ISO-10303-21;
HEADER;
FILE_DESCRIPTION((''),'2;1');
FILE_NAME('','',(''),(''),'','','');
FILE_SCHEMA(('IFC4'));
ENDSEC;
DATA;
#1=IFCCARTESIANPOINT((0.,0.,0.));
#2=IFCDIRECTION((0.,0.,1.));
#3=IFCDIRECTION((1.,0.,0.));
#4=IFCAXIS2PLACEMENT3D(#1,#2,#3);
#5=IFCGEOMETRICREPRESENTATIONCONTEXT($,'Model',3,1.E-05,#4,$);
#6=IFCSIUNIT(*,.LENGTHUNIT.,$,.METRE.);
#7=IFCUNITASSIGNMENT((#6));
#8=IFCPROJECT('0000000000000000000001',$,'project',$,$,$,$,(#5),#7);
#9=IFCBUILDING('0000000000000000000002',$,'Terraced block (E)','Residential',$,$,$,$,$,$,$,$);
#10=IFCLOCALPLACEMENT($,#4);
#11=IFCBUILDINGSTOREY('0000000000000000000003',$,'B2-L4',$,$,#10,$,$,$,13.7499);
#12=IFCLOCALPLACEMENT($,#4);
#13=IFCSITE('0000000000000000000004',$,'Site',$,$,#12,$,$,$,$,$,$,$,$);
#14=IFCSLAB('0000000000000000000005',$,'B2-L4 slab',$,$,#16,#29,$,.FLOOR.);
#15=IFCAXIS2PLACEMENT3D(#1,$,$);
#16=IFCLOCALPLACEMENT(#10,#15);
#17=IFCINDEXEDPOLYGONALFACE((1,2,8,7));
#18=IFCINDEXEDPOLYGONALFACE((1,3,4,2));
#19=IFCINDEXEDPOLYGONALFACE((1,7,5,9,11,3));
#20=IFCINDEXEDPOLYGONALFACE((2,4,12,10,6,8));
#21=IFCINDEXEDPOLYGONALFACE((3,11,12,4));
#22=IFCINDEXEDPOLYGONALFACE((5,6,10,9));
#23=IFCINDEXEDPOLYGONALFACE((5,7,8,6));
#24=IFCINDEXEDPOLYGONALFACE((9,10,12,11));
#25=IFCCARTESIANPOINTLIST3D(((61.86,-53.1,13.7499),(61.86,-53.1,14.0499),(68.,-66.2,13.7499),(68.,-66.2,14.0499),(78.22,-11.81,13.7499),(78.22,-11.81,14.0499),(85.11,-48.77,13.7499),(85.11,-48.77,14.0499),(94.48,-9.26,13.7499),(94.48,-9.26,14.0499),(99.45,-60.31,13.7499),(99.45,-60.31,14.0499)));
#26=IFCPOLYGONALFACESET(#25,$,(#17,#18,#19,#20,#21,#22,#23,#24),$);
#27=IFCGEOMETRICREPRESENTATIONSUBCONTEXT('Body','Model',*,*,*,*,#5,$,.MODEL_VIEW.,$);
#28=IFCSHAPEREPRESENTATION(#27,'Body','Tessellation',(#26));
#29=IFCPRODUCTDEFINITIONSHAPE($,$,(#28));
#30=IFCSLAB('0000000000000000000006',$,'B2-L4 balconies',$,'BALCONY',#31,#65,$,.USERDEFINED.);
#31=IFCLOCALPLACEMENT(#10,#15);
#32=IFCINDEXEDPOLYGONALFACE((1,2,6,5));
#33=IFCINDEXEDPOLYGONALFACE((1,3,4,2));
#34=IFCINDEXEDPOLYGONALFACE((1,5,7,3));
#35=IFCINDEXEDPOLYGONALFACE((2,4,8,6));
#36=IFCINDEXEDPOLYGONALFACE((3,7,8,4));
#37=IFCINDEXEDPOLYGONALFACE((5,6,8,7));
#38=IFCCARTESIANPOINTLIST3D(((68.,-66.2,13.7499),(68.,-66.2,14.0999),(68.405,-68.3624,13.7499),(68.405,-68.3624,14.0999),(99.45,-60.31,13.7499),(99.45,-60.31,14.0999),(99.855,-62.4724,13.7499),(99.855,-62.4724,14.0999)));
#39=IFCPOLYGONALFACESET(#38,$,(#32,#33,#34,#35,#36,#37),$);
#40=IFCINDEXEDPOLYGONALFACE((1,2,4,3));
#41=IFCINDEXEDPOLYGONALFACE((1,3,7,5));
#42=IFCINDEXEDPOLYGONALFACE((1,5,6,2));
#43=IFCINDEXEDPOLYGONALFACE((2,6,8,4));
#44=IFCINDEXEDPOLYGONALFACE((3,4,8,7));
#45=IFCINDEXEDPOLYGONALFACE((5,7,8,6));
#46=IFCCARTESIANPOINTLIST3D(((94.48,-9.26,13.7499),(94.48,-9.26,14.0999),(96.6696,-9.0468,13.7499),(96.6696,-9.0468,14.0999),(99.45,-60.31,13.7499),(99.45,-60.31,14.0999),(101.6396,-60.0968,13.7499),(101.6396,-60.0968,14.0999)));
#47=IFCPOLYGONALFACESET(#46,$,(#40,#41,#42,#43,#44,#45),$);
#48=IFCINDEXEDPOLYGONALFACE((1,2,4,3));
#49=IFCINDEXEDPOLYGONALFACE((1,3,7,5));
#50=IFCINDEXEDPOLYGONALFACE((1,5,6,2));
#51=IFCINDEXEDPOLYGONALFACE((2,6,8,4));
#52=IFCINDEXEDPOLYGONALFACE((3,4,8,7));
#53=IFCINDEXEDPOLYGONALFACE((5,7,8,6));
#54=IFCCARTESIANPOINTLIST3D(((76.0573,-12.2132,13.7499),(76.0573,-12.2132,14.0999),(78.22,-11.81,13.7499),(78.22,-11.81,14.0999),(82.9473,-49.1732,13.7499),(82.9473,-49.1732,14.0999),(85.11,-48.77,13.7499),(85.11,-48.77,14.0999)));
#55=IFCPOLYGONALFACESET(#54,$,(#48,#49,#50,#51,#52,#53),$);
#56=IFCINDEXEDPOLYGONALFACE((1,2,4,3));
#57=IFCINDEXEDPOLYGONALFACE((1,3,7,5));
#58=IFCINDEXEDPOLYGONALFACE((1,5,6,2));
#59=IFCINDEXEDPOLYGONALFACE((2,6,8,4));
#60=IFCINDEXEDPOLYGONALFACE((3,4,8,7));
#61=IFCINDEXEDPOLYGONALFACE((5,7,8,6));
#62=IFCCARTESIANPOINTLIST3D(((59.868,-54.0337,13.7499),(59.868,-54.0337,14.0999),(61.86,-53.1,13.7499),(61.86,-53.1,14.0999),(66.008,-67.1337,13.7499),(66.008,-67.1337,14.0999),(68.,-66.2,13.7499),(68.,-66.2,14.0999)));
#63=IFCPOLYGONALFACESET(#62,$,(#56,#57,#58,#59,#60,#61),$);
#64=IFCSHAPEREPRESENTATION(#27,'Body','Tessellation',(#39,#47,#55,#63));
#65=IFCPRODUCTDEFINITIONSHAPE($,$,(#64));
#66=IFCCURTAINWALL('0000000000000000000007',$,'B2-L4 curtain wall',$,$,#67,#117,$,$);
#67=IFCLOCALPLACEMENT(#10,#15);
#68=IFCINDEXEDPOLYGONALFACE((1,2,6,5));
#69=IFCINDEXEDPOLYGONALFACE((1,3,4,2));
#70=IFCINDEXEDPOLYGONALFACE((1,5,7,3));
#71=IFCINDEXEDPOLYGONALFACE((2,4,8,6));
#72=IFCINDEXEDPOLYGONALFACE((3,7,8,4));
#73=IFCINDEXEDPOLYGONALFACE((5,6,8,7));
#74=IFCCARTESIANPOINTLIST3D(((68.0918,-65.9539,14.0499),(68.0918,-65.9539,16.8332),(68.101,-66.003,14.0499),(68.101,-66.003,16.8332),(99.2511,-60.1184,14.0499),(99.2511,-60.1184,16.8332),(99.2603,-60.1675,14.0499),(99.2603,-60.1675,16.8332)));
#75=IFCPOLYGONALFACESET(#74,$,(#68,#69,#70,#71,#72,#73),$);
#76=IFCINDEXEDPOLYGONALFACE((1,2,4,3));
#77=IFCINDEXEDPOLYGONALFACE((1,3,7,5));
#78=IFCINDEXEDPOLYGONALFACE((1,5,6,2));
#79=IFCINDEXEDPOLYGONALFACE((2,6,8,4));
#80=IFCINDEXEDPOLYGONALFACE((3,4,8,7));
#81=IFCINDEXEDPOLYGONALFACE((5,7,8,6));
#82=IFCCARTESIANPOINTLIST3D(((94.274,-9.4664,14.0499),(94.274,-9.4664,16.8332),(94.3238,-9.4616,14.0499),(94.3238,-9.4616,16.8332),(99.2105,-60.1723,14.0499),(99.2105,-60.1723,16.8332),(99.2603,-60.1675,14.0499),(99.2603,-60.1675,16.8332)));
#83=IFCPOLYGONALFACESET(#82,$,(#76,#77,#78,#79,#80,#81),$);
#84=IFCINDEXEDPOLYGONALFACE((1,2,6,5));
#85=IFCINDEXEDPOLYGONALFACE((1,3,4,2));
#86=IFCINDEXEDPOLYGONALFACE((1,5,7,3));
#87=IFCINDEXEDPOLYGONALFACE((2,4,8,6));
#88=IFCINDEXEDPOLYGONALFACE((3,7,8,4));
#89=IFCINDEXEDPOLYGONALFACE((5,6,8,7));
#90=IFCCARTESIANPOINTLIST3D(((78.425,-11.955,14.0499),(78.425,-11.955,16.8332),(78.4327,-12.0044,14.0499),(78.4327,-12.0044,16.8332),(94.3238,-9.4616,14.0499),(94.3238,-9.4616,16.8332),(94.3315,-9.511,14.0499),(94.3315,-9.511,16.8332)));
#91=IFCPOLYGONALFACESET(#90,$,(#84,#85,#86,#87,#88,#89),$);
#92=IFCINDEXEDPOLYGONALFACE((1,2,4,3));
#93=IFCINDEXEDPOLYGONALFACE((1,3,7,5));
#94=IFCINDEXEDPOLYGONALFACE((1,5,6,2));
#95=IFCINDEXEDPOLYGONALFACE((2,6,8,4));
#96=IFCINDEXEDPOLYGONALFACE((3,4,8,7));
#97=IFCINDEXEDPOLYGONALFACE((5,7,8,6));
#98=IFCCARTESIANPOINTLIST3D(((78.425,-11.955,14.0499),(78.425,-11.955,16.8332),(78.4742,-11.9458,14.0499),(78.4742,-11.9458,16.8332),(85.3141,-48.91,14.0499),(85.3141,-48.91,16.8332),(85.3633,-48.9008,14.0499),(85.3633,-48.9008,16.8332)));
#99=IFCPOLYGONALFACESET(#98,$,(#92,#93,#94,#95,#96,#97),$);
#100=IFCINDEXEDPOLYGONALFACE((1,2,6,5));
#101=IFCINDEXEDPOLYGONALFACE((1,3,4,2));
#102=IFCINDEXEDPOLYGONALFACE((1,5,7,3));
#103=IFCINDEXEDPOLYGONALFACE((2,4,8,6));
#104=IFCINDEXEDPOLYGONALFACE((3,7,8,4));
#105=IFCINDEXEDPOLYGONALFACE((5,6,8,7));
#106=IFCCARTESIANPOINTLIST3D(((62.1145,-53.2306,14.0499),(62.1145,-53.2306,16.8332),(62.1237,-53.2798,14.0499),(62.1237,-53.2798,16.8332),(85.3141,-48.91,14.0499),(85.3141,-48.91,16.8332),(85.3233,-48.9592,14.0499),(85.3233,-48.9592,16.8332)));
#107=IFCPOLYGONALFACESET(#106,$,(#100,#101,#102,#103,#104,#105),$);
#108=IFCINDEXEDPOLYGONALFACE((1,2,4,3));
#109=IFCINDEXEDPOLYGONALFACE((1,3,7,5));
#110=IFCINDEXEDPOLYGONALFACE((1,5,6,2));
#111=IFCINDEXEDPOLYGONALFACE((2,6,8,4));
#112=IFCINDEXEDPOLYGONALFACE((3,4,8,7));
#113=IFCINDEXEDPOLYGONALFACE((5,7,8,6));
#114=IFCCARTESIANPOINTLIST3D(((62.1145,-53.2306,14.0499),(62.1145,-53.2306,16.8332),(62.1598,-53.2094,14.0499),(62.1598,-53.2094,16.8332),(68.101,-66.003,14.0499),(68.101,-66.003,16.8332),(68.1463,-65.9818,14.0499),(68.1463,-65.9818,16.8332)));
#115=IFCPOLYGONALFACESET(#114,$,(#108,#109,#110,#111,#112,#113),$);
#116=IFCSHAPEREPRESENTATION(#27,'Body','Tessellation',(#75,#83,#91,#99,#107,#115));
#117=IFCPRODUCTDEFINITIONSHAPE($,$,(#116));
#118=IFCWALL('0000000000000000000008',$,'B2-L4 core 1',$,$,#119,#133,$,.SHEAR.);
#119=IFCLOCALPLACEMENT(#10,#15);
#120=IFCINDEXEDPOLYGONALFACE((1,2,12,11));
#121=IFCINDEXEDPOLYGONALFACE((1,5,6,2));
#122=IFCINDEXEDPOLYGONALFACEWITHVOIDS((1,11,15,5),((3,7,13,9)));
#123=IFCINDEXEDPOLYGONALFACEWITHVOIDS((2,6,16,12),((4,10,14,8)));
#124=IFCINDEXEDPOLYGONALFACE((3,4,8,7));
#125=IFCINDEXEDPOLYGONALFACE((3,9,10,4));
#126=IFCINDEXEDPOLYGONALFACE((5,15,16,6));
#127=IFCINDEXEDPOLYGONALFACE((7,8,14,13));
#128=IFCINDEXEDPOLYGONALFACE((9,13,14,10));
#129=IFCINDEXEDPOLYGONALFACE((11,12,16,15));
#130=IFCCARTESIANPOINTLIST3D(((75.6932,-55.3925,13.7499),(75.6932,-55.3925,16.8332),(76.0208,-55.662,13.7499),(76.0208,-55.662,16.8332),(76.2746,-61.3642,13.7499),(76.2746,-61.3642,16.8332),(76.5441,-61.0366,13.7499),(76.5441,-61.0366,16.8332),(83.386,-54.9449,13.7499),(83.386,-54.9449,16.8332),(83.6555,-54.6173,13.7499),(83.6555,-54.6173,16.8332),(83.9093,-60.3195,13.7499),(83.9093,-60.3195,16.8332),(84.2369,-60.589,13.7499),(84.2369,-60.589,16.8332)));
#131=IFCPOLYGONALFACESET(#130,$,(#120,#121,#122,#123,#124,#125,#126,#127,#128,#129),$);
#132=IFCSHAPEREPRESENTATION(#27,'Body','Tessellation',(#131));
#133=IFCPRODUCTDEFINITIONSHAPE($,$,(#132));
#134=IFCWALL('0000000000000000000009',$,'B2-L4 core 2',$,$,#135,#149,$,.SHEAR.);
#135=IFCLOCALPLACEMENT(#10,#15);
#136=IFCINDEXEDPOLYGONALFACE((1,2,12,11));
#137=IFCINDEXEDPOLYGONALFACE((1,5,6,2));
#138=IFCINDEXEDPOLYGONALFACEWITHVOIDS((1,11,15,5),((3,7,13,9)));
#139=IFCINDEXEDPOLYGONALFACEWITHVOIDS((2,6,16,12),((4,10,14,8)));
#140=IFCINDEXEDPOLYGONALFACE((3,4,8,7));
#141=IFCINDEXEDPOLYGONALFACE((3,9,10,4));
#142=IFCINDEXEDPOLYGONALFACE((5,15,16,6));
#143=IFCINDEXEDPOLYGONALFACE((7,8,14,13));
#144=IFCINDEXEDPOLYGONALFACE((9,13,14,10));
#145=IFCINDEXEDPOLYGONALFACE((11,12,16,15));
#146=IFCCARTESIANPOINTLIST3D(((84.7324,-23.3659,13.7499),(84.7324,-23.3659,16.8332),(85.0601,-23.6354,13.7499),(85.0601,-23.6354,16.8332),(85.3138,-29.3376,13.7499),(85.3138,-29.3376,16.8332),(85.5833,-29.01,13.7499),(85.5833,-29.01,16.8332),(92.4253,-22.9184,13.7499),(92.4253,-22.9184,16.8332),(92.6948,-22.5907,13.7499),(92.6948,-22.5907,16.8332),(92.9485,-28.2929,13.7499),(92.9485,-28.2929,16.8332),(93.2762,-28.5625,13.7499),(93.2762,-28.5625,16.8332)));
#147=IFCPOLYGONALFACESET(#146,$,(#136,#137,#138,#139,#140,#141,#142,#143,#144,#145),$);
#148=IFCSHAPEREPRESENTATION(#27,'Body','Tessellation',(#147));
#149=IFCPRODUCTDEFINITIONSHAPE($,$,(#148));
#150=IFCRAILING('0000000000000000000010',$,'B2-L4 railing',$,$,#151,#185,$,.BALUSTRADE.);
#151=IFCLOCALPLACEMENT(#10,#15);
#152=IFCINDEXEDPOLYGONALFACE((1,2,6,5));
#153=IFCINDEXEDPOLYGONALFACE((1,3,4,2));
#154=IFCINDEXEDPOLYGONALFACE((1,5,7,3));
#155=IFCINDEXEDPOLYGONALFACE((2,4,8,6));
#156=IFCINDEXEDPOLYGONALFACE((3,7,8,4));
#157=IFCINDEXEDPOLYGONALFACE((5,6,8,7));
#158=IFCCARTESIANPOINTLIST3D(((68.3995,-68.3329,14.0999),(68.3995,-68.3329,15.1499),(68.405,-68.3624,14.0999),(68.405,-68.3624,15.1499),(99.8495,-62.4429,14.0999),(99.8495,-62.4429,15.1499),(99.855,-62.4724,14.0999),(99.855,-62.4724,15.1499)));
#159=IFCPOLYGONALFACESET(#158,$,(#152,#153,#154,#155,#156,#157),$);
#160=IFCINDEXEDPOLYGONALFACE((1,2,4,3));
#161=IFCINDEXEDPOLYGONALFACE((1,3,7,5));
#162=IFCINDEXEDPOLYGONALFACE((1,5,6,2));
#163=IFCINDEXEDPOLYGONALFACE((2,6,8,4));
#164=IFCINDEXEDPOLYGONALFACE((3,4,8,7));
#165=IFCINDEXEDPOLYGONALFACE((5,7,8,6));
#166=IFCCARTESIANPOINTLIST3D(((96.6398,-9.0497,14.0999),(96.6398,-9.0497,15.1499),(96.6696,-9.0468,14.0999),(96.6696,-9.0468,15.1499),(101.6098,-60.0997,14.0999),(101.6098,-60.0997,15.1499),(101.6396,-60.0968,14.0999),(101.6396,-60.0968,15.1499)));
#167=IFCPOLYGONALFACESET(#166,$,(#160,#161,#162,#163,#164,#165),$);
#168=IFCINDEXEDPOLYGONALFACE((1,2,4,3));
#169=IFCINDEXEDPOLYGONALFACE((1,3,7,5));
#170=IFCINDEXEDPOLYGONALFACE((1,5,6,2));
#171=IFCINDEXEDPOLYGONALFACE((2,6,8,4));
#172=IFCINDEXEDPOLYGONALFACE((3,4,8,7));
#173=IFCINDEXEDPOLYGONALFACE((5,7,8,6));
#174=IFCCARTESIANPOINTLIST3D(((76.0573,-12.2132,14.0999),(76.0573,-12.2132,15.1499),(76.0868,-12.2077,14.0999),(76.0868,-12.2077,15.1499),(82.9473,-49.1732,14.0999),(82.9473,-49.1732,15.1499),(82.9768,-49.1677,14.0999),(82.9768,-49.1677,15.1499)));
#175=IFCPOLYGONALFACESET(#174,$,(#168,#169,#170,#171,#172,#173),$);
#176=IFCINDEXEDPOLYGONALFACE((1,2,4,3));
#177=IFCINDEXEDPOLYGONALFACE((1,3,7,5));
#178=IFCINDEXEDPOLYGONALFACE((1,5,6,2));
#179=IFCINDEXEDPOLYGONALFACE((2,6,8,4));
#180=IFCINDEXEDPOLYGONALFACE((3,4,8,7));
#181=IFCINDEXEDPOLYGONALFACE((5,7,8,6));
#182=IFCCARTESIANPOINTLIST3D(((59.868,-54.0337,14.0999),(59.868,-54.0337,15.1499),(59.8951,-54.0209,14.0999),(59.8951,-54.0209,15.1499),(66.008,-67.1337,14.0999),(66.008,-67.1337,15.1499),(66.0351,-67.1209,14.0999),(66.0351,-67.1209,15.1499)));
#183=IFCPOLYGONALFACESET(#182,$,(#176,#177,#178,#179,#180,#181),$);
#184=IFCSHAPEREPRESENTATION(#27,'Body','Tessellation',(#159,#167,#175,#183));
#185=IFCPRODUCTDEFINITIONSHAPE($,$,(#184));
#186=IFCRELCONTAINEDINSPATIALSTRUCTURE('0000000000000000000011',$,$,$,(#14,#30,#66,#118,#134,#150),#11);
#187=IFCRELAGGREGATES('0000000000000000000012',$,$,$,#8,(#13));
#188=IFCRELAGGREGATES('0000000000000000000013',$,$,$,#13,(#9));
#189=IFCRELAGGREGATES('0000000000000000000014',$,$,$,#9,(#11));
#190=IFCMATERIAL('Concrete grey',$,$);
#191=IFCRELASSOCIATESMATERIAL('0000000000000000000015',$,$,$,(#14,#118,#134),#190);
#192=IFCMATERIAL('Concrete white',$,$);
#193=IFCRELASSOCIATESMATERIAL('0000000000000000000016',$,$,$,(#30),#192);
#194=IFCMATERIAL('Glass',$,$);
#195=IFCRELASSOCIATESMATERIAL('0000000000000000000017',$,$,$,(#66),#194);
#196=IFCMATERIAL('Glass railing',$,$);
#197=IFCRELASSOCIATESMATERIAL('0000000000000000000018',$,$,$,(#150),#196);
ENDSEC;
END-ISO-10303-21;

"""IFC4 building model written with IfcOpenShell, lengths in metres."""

from ifc_helpers import new_model, si_unit, frame, origin_with_axes, place, context, subcontext, project, spatial, polyline, outline, extrude, material, element, save


model = new_model("IFC4")

# Units and contexts
model_context = context("Model", 3, precision=1e-05, world=origin_with_axes())
body_context = subcontext(model_context, "Body", "Model", "MODEL_VIEW")
ifc_project = project(units=[si_unit("LENGTHUNIT", "METRE")], contexts=[model_context])

# Site, building, storey
site_placement = place(None, origin_with_axes())
site = spatial("IfcSite", under=ifc_project, at=site_placement, Name="Site")
building = spatial("IfcBuilding", under=site, Name="Terraced block (E)", Description="Residential")
storey_placement = place(None, origin_with_axes())
storey = spatial("IfcBuildingStorey", under=building, at=storey_placement, Name="B2-L4", Elevation=13.7499)

# Slabs
ifc_material_1 = material(Name="Concrete grey")
slab_1_placement = place(storey_placement, origin_with_axes())
element("IfcSlab", 1, at=slab_1_placement, inside=storey, material=ifc_material_1, Name="B2-L4 slab", PredefinedType="FLOOR", context=body_context, shape_type="SweptSolid", body=[
    extrude(outline(polyline([(68.0, -66.2), (99.45, -60.31), (94.48, -9.26), (78.22, -11.81), (85.11, -48.77), (61.86, -53.1), (68.0, -66.2)])), frame((0.0, 0.0, 13.7499), z_axis=(0.0, 0.0, 1.0), x_axis=(1.0, 0.0, 0.0)), (0.0, 0.0, 1.0), 0.3),
])
ifc_material_2 = material(Name="Concrete white")
slab_2_placement = place(storey_placement, origin_with_axes())
element("IfcSlab", 2, at=slab_2_placement, inside=storey, material=ifc_material_2, Name="B2-L4 balconies", ObjectType="BALCONY", PredefinedType="USERDEFINED", context=body_context, shape_type="SweptSolid", body=[
    extrude(outline(polyline([(68.0, -66.2), (99.45, -60.31), (99.855, -62.4724), (68.405, -68.3624), (68.0, -66.2)])), frame((0.0, 0.0, 13.7499), z_axis=(0.0, 0.0, 1.0), x_axis=(1.0, 0.0, 0.0)), (0.0, 0.0, 1.0), 0.35),
    extrude(outline(polyline([(99.45, -60.31), (94.48, -9.26), (96.6696, -9.0468), (101.6396, -60.0968), (99.45, -60.31)])), frame((0.0, 0.0, 13.7499), z_axis=(0.0, 0.0, 1.0), x_axis=(1.0, 0.0, 0.0)), (0.0, 0.0, 1.0), 0.35),
    extrude(outline(polyline([(78.22, -11.81), (85.11, -48.77), (82.9473, -49.1732), (76.0573, -12.2132), (78.22, -11.81)])), frame((0.0, 0.0, 13.7499), z_axis=(0.0, 0.0, 1.0), x_axis=(1.0, 0.0, 0.0)), (0.0, 0.0, 1.0), 0.35),
    extrude(outline(polyline([(61.86, -53.1), (68.0, -66.2), (66.008, -67.1337), (59.868, -54.0337), (61.86, -53.1)])), frame((0.0, 0.0, 13.7499), z_axis=(0.0, 0.0, 1.0), x_axis=(1.0, 0.0, 0.0)), (0.0, 0.0, 1.0), 0.35),
])

# Curtain wall
ifc_material_3 = material(Name="Glass")
curtain_wall_placement = place(storey_placement, origin_with_axes())
element("IfcCurtainWall", 3, at=curtain_wall_placement, inside=storey, material=ifc_material_3, Name="B2-L4 curtain wall", context=body_context, shape_type="SweptSolid", body=[
    extrude(outline(polyline([(68.101, -66.003), (99.2603, -60.1675), (99.2511, -60.1184), (68.0918, -65.9539), (68.101, -66.003)])), frame((0.0, 0.0, 14.0499), z_axis=(0.0, 0.0, 1.0), x_axis=(1.0, 0.0, 0.0)), (0.0, 0.0, 1.0), 2.7833),
    extrude(outline(polyline([(99.2603, -60.1675), (94.3238, -9.4616), (94.274, -9.4664), (99.2105, -60.1723), (99.2603, -60.1675)])), frame((0.0, 0.0, 14.0499), z_axis=(0.0, 0.0, 1.0), x_axis=(1.0, 0.0, 0.0)), (0.0, 0.0, 1.0), 2.7833),
    extrude(outline(polyline([(94.3238, -9.4616), (78.425, -11.955), (78.4327, -12.0044), (94.3315, -9.511), (94.3238, -9.4616)])), frame((0.0, 0.0, 14.0499), z_axis=(0.0, 0.0, 1.0), x_axis=(1.0, 0.0, 0.0)), (0.0, 0.0, 1.0), 2.7833),
    extrude(outline(polyline([(78.425, -11.955), (85.3141, -48.91), (85.3633, -48.9008), (78.4742, -11.9458), (78.425, -11.955)])), frame((0.0, 0.0, 14.0499), z_axis=(0.0, 0.0, 1.0), x_axis=(1.0, 0.0, 0.0)), (0.0, 0.0, 1.0), 2.7833),
    extrude(outline(polyline([(85.3141, -48.91), (62.1145, -53.2306), (62.1237, -53.2798), (85.3233, -48.9592), (85.3141, -48.91)])), frame((0.0, 0.0, 14.0499), z_axis=(0.0, 0.0, 1.0), x_axis=(1.0, 0.0, 0.0)), (0.0, 0.0, 1.0), 2.7833),
    extrude(outline(polyline([(62.1145, -53.2306), (68.101, -66.003), (68.1463, -65.9818), (62.1598, -53.2094), (62.1145, -53.2306)])), frame((0.0, 0.0, 14.0499), z_axis=(0.0, 0.0, 1.0), x_axis=(1.0, 0.0, 0.0)), (0.0, 0.0, 1.0), 2.7833),
])

# Walls
wall_1_placement = place(storey_placement, origin_with_axes())
element("IfcWall", 4, at=wall_1_placement, inside=storey, material=ifc_material_1, Name="B2-L4 core 1", PredefinedType="SHEAR", context=body_context, shape_type="SweptSolid", body=[
    extrude(outline(polyline([(84.2369, -60.589), (83.6555, -54.6173), (75.6932, -55.3925), (76.2746, -61.3642), (84.2369, -60.589)]), holes=[polyline([(83.9093, -60.3195), (83.386, -54.9449), (76.0208, -55.662), (76.5441, -61.0366), (83.9093, -60.3195)])]), frame((0.0, 0.0, 13.7499), z_axis=(0.0, 0.0, 1.0), x_axis=(1.0, 0.0, 0.0)), (0.0, 0.0, 1.0), 3.0833),
])
wall_2_placement = place(storey_placement, origin_with_axes())
element("IfcWall", 5, at=wall_2_placement, inside=storey, material=ifc_material_1, Name="B2-L4 core 2", PredefinedType="SHEAR", context=body_context, shape_type="SweptSolid", body=[
    extrude(outline(polyline([(93.2762, -28.5625), (92.6948, -22.5907), (84.7324, -23.3659), (85.3138, -29.3376), (93.2762, -28.5625)]), holes=[polyline([(92.9485, -28.2929), (92.4253, -22.9184), (85.0601, -23.6354), (85.5833, -29.01), (92.9485, -28.2929)])]), frame((0.0, 0.0, 13.7499), z_axis=(0.0, 0.0, 1.0), x_axis=(1.0, 0.0, 0.0)), (0.0, 0.0, 1.0), 3.0833),
])

# Railing
ifc_material_4 = material(Name="Glass railing")
railing_placement = place(storey_placement, origin_with_axes())
element("IfcRailing", 6, at=railing_placement, inside=storey, material=ifc_material_4, Name="B2-L4 railing", PredefinedType="BALUSTRADE", context=body_context, shape_type="SweptSolid", body=[
    extrude(outline(polyline([(68.405, -68.3624), (99.855, -62.4724), (99.8495, -62.4429), (68.3995, -68.3329), (68.405, -68.3624)])), frame((0.0, 0.0, 14.0999), z_axis=(0.0, 0.0, 1.0), x_axis=(1.0, 0.0, 0.0)), (0.0, 0.0, 1.0), 1.05),
    extrude(outline(polyline([(101.6396, -60.0968), (96.6696, -9.0468), (96.6398, -9.0497), (101.6098, -60.0997), (101.6396, -60.0968)])), frame((0.0, 0.0, 14.0999), z_axis=(0.0, 0.0, 1.0), x_axis=(1.0, 0.0, 0.0)), (0.0, 0.0, 1.0), 1.05),
    extrude(outline(polyline([(76.0573, -12.2132), (82.9473, -49.1732), (82.9768, -49.1677), (76.0868, -12.2077), (76.0573, -12.2132)])), frame((0.0, 0.0, 14.0999), z_axis=(0.0, 0.0, 1.0), x_axis=(1.0, 0.0, 0.0)), (0.0, 0.0, 1.0), 1.05),
    extrude(outline(polyline([(59.868, -54.0337), (66.008, -67.1337), (66.0351, -67.1209), (59.8951, -54.0209), (59.868, -54.0337)])), frame((0.0, 0.0, 14.0999), z_axis=(0.0, 0.0, 1.0), x_axis=(1.0, 0.0, 0.0)), (0.0, 0.0, 1.0), 1.05),
])

save(model, "model.ifc")
